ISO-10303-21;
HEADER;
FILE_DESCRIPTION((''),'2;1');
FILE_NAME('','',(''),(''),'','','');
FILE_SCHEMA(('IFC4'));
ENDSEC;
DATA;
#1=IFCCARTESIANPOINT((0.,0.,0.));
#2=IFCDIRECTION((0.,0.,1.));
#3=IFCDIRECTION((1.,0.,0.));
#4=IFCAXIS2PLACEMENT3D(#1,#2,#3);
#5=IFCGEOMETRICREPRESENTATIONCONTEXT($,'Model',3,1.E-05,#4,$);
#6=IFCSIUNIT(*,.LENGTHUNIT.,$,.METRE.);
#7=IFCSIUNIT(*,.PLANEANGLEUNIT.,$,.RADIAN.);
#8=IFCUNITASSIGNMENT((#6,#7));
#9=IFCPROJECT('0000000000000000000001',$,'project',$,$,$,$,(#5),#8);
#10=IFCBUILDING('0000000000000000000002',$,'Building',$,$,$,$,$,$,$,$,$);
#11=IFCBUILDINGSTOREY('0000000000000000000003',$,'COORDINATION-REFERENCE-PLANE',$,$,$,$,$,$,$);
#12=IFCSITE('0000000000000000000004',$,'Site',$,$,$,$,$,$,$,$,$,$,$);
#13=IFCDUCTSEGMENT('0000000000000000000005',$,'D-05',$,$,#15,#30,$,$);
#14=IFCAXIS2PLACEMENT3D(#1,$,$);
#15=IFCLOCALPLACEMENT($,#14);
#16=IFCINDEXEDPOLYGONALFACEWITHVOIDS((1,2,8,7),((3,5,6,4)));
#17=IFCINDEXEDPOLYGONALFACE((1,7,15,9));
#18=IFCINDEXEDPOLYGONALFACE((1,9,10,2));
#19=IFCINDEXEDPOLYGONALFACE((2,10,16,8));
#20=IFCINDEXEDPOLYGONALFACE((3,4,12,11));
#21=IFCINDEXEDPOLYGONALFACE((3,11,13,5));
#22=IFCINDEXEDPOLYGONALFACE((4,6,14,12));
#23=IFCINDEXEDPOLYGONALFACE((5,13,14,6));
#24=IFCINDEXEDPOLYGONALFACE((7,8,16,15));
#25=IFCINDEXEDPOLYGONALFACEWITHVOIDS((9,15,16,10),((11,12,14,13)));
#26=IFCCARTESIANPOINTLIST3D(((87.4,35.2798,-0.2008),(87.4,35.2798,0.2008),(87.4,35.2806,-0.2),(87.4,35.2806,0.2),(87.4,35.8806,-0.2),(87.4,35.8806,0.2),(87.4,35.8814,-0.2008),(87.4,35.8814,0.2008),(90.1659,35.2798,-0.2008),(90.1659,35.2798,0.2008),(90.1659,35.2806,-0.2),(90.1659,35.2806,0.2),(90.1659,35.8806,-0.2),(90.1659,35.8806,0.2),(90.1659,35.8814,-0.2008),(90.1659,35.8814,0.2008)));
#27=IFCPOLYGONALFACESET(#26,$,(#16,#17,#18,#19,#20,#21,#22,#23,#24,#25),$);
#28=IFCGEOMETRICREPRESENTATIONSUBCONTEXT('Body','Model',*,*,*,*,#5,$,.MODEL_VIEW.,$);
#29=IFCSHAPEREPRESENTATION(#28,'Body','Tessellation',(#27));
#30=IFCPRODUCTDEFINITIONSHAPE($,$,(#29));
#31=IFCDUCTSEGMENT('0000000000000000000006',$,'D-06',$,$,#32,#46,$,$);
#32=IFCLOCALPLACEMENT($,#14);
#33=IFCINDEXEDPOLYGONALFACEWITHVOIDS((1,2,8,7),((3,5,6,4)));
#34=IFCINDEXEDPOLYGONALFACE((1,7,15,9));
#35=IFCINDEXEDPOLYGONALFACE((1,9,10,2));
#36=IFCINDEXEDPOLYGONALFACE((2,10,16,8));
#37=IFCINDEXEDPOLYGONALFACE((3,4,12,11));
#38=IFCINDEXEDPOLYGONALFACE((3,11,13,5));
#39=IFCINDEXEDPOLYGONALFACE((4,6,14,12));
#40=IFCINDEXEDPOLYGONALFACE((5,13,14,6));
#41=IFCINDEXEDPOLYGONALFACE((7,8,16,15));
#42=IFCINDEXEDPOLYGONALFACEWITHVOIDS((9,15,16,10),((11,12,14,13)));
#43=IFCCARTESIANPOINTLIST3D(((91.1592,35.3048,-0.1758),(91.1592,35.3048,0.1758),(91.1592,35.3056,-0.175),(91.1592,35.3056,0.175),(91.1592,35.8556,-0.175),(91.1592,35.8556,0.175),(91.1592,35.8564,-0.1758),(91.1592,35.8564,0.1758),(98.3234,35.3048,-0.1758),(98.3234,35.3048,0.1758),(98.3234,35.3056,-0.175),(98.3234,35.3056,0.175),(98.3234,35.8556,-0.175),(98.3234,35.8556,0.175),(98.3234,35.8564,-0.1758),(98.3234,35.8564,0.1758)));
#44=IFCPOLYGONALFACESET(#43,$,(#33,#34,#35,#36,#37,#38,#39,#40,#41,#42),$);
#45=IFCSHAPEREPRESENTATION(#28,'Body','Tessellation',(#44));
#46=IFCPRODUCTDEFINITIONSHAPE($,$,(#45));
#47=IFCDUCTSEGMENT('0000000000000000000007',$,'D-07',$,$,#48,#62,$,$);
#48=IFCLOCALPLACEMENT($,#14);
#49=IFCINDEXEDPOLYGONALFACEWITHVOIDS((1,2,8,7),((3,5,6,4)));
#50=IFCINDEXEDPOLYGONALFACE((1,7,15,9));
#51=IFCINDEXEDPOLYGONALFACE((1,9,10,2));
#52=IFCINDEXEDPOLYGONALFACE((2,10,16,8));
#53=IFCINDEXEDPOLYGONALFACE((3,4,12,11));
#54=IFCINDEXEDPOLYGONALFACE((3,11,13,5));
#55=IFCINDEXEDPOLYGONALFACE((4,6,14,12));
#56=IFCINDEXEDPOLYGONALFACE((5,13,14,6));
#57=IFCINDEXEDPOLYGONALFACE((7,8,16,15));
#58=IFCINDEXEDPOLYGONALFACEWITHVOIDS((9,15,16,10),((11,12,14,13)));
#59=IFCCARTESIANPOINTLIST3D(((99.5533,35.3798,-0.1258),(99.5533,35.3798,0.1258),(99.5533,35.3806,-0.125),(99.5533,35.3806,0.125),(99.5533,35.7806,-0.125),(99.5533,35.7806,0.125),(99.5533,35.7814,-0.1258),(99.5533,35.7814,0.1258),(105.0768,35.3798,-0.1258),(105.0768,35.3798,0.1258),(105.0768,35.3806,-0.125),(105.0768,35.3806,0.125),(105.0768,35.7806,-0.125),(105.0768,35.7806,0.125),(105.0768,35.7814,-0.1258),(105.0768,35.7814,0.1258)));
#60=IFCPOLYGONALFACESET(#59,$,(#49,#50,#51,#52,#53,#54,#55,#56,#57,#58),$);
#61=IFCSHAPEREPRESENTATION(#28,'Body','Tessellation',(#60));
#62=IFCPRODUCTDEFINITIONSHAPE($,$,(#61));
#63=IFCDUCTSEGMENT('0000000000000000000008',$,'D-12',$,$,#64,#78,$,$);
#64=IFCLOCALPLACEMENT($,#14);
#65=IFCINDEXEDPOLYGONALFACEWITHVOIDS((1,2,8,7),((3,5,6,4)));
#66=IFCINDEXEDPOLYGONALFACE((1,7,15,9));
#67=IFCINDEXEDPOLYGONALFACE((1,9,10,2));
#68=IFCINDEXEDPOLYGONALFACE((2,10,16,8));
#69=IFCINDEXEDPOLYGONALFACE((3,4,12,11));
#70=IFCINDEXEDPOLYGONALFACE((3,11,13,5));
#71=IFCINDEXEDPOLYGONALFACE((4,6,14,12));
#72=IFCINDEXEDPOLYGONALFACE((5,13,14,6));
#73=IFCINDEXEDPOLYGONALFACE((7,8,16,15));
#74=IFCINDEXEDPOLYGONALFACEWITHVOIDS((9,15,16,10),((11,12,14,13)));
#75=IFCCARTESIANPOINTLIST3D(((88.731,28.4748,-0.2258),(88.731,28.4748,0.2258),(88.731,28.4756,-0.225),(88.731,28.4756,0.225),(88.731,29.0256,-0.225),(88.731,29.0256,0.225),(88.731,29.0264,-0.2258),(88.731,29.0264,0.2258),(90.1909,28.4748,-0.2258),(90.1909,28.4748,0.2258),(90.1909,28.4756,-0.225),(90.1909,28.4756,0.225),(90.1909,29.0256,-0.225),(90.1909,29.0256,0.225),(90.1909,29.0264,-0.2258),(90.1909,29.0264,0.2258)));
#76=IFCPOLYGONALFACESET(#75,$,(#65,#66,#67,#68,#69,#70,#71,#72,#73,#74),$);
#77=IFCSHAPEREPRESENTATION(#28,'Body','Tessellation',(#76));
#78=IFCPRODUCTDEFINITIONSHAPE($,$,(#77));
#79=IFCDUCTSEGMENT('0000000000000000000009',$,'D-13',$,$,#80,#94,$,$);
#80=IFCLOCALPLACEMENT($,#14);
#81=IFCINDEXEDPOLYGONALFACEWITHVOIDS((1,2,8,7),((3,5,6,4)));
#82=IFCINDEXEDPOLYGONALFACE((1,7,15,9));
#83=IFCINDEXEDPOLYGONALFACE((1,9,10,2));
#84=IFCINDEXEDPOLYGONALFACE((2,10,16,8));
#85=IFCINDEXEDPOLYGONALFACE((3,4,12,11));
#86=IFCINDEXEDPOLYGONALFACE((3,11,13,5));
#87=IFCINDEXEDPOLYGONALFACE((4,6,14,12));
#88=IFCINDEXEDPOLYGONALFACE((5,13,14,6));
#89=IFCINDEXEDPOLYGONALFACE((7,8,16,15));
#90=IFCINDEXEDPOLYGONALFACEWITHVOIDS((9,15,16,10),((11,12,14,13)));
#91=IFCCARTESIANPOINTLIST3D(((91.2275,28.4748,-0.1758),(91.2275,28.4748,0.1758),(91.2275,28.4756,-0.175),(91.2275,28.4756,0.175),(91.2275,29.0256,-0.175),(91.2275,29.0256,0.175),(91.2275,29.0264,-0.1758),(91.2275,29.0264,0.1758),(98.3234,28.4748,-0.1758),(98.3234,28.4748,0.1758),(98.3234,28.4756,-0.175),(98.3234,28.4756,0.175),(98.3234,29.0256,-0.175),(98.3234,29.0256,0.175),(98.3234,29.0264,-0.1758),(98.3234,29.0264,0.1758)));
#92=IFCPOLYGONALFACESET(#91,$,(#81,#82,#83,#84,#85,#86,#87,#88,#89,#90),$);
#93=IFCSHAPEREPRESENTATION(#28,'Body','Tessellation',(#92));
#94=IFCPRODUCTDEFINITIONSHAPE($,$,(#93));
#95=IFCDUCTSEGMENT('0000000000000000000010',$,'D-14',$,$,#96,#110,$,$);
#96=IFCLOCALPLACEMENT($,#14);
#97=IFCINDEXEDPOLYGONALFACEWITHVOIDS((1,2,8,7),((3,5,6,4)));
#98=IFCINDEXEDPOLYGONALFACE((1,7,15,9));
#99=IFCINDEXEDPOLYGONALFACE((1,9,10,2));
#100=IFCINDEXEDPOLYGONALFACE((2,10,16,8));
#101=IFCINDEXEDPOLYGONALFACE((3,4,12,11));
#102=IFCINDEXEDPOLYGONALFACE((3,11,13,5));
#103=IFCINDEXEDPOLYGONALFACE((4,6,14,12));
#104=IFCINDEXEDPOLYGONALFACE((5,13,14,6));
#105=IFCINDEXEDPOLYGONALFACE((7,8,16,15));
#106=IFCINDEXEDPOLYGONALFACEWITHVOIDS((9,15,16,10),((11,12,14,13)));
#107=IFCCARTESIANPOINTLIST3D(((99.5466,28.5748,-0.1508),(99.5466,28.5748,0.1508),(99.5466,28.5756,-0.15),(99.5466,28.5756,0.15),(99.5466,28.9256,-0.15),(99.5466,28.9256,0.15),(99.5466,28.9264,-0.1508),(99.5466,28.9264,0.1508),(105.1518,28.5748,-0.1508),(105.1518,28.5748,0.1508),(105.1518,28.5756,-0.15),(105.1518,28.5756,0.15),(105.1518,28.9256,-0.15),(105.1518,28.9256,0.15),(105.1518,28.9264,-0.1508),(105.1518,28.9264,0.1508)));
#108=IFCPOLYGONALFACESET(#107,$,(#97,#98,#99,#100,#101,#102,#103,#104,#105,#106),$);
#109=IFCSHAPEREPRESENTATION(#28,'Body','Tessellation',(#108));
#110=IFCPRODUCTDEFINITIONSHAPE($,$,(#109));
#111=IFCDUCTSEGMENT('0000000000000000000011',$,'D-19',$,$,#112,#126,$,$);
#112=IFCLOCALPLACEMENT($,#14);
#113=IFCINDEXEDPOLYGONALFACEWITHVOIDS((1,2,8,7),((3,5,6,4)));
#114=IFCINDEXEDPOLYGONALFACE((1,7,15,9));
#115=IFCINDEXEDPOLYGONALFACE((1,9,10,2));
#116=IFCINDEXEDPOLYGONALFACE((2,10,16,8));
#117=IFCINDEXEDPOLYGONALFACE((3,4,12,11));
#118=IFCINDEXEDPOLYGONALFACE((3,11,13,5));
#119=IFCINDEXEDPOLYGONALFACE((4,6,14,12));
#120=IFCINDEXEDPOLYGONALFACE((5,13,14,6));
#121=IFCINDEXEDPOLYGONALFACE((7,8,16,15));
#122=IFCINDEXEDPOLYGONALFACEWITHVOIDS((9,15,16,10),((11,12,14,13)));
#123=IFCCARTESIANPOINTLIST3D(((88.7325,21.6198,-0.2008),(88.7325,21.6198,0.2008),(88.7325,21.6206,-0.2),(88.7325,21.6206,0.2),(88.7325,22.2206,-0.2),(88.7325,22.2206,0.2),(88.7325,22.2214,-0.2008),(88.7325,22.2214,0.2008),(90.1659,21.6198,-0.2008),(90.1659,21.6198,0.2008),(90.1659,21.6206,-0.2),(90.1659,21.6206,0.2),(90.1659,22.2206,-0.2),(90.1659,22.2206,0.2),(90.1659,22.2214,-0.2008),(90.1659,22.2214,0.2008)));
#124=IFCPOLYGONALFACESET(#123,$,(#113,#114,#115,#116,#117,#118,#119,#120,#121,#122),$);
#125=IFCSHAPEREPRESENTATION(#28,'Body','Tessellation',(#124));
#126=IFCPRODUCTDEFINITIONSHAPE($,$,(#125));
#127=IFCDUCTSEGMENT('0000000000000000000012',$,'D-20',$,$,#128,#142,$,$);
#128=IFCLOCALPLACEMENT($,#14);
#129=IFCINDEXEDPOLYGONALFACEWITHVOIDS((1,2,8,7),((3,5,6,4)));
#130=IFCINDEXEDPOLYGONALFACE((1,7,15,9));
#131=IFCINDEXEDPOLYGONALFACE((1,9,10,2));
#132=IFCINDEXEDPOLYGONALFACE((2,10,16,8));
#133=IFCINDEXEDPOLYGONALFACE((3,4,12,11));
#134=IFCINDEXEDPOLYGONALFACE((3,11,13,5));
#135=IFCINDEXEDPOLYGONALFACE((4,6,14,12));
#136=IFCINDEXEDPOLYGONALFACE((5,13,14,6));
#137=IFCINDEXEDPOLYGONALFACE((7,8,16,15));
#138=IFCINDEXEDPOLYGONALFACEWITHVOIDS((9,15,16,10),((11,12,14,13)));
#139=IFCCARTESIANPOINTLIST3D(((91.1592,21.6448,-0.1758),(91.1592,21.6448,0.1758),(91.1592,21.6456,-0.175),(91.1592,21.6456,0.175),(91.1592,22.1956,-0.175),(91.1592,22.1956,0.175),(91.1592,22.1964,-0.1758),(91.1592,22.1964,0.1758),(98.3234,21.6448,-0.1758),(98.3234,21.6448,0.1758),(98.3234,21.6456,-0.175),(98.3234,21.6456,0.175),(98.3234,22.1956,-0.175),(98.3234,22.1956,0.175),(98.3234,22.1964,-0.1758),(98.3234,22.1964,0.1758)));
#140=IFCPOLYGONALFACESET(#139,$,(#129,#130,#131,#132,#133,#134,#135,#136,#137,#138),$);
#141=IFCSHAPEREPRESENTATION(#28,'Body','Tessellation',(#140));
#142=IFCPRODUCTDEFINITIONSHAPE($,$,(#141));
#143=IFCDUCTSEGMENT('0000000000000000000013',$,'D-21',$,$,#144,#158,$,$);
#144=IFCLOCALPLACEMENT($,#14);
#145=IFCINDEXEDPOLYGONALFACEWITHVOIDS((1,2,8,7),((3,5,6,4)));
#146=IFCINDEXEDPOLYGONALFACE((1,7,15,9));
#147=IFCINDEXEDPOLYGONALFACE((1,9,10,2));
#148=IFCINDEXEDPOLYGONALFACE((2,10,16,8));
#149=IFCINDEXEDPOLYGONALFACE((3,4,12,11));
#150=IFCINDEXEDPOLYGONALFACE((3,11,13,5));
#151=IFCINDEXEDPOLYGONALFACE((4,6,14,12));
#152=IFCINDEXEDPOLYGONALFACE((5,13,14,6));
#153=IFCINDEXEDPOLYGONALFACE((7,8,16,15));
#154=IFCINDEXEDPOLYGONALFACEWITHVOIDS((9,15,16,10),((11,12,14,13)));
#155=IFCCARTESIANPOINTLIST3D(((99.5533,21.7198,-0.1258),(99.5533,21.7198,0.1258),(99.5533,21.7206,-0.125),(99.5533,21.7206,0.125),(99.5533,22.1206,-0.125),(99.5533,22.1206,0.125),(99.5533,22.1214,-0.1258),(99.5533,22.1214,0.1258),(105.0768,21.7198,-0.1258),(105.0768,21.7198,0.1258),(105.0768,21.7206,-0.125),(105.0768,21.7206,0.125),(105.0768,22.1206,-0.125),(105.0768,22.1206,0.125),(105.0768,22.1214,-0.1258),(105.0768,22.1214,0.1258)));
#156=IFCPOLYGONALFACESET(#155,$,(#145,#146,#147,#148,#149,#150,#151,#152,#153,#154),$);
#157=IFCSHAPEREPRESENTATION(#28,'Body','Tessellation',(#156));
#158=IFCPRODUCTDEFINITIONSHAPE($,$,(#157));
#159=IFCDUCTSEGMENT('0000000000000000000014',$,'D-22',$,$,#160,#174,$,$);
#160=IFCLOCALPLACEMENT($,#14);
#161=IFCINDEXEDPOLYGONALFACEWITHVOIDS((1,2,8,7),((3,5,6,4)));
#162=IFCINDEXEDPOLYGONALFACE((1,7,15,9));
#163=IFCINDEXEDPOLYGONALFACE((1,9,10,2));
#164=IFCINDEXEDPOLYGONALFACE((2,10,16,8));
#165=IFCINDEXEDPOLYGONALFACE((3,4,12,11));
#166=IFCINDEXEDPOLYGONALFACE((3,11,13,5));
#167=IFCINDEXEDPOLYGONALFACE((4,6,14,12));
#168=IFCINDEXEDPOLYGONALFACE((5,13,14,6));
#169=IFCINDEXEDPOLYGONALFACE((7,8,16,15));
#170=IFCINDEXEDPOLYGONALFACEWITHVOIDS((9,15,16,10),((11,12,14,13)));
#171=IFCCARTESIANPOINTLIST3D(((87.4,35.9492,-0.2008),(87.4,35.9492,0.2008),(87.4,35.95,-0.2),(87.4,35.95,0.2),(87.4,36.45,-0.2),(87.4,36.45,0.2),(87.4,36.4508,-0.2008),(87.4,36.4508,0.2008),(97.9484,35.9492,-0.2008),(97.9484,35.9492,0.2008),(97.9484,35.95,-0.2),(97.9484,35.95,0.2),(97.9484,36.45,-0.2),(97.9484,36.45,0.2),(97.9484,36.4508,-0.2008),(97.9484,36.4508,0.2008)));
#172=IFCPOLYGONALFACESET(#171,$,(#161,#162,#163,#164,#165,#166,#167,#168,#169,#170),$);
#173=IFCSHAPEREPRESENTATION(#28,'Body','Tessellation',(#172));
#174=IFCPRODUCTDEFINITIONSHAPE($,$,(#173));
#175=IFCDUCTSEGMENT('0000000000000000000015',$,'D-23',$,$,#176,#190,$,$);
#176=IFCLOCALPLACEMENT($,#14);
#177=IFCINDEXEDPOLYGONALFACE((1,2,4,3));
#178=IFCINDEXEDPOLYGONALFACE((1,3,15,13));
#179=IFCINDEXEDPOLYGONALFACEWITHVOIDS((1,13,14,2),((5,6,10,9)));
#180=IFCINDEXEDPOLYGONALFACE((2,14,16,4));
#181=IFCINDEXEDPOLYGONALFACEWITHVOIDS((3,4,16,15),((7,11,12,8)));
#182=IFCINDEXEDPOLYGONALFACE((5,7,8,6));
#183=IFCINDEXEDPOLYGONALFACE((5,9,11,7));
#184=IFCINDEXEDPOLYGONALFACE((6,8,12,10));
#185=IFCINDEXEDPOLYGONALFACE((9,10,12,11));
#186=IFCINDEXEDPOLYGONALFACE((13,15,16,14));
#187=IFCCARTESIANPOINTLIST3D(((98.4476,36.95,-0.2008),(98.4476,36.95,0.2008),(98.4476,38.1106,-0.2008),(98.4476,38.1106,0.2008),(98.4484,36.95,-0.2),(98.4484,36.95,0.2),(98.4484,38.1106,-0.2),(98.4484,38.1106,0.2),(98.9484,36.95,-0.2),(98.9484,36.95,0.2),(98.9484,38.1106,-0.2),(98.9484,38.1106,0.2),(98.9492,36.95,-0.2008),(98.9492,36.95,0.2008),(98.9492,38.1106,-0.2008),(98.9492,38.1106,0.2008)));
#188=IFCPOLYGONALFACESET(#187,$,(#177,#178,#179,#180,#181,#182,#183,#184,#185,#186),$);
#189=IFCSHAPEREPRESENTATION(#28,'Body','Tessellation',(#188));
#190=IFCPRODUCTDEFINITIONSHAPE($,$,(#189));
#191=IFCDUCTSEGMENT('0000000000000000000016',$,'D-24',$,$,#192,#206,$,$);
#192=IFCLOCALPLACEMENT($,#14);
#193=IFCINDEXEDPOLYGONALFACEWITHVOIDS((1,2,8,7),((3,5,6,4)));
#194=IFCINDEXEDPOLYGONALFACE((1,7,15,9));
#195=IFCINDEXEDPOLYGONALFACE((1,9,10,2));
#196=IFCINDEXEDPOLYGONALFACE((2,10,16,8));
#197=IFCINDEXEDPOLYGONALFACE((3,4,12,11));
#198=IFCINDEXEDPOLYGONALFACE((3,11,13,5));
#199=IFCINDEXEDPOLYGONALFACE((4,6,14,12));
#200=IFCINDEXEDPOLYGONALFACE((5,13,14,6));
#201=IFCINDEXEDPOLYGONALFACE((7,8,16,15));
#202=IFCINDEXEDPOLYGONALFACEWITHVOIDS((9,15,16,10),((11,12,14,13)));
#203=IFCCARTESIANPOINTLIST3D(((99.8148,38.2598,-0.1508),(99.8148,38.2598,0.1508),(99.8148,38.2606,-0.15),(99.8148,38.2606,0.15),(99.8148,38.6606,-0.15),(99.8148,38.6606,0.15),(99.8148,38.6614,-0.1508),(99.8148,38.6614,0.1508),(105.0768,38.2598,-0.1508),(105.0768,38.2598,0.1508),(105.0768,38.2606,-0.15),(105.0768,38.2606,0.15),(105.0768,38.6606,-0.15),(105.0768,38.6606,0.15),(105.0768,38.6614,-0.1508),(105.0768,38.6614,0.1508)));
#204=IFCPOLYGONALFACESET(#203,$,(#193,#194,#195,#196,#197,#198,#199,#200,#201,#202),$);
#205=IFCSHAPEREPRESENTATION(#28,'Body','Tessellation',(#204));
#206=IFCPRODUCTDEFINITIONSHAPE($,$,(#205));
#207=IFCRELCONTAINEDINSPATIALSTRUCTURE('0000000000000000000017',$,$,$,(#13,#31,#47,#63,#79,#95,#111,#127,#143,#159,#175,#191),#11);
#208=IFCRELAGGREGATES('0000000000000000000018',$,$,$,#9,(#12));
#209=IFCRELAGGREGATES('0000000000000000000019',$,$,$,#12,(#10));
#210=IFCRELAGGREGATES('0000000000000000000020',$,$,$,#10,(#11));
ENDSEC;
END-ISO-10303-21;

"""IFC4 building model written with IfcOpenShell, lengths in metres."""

from ifc_helpers import new_model, si_unit, frame, origin, origin_with_axes, place, context, subcontext, project, spatial, hollow_rectangle, extrude, element, save


model = new_model("IFC4")

# Units and contexts
model_context = context("Model", 3, precision=1e-05, world=origin_with_axes())
body_context = subcontext(model_context, "Body", "Model", "MODEL_VIEW")
ifc_project = project(units=[si_unit("LENGTHUNIT", "METRE"), si_unit("PLANEANGLEUNIT", "RADIAN")], contexts=[model_context])

# Site, building, storey
site = spatial("IfcSite", under=ifc_project, Name="Site")
building = spatial("IfcBuilding", under=site, Name="Building")
storey = spatial("IfcBuildingStorey", under=building, Name="COORDINATION-REFERENCE-PLANE")

# Duct segments
duct_segment_1_placement = place(None, frame((87.4, 35.5806, 0.0), z_axis=(1.0, 0.0, 0.0), x_axis=(0.0, 1.0, 0.0)))
element("IfcDuctSegment", 1, at=duct_segment_1_placement, inside=storey, Name="D-05", context=body_context, shape_type="SweptSolid", body=[
    extrude(hollow_rectangle(XDim=0.6016, YDim=0.4016, WallThickness=0.0008), origin(), (0.0, 0.0, 1.0), 2.7659),
])
duct_segment_2_placement = place(None, frame((91.1592, 35.5806, 0.0), z_axis=(1.0, 0.0, 0.0), x_axis=(0.0, 1.0, 0.0)))
element("IfcDuctSegment", 2, at=duct_segment_2_placement, inside=storey, Name="D-06", context=body_context, shape_type="SweptSolid", body=[
    extrude(hollow_rectangle(XDim=0.5516, YDim=0.3516, WallThickness=0.0008), origin(), (0.0, 0.0, 1.0), 7.1642),
])
duct_segment_3_placement = place(None, frame((99.5533, 35.5806, 0.0), z_axis=(1.0, 0.0, 0.0), x_axis=(0.0, 1.0, 0.0)))
element("IfcDuctSegment", 3, at=duct_segment_3_placement, inside=storey, Name="D-07", context=body_context, shape_type="SweptSolid", body=[
    extrude(hollow_rectangle(XDim=0.4016, YDim=0.2516, WallThickness=0.0008), origin(), (0.0, 0.0, 1.0), 5.5234),
])
duct_segment_4_placement = place(None, frame((88.731, 28.7506, 0.0), z_axis=(1.0, 0.0, 0.0), x_axis=(0.0, 1.0, 0.0)))
element("IfcDuctSegment", 4, at=duct_segment_4_placement, inside=storey, Name="D-12", context=body_context, shape_type="SweptSolid", body=[
    extrude(hollow_rectangle(XDim=0.5516, YDim=0.4516, WallThickness=0.0008), origin(), (0.0, 0.0, 1.0), 1.4599),
])
duct_segment_5_placement = place(None, frame((91.2275, 28.7506, 0.0), z_axis=(1.0, 0.0, 0.0), x_axis=(0.0, 1.0, 0.0)))
element("IfcDuctSegment", 5, at=duct_segment_5_placement, inside=storey, Name="D-13", context=body_context, shape_type="SweptSolid", body=[
    extrude(hollow_rectangle(XDim=0.5516, YDim=0.3516, WallThickness=0.0008), origin(), (0.0, 0.0, 1.0), 7.0959),
])
duct_segment_6_placement = place(None, frame((99.5466, 28.7506, 0.0), z_axis=(1.0, 0.0, 0.0), x_axis=(0.0, 1.0, 0.0)))
element("IfcDuctSegment", 6, at=duct_segment_6_placement, inside=storey, Name="D-14", context=body_context, shape_type="SweptSolid", body=[
    extrude(hollow_rectangle(XDim=0.3516, YDim=0.3016, WallThickness=0.0008), origin(), (0.0, 0.0, 1.0), 5.6051),
])
duct_segment_7_placement = place(None, frame((88.7325, 21.9206, 0.0), z_axis=(1.0, 0.0, 0.0), x_axis=(0.0, 1.0, 0.0)))
element("IfcDuctSegment", 7, at=duct_segment_7_placement, inside=storey, Name="D-19", context=body_context, shape_type="SweptSolid", body=[
    extrude(hollow_rectangle(XDim=0.6016, YDim=0.4016, WallThickness=0.0008), origin(), (0.0, 0.0, 1.0), 1.4334),
])
duct_segment_8_placement = place(None, frame((91.1592, 21.9206, 0.0), z_axis=(1.0, 0.0, 0.0), x_axis=(0.0, 1.0, 0.0)))
element("IfcDuctSegment", 8, at=duct_segment_8_placement, inside=storey, Name="D-20", context=body_context, shape_type="SweptSolid", body=[
    extrude(hollow_rectangle(XDim=0.5516, YDim=0.3516, WallThickness=0.0008), origin(), (0.0, 0.0, 1.0), 7.1642),
])
duct_segment_9_placement = place(None, frame((99.5533, 21.9206, 0.0), z_axis=(1.0, 0.0, 0.0), x_axis=(0.0, 1.0, 0.0)))
element("IfcDuctSegment", 9, at=duct_segment_9_placement, inside=storey, Name="D-21", context=body_context, shape_type="SweptSolid", body=[
    extrude(hollow_rectangle(XDim=0.4016, YDim=0.2516, WallThickness=0.0008), origin(), (0.0, 0.0, 1.0), 5.5234),
])
duct_segment_10_placement = place(None, frame((87.4, 36.2, 0.0), z_axis=(1.0, 0.0, 0.0), x_axis=(0.0, 1.0, 0.0)))
element("IfcDuctSegment", 10, at=duct_segment_10_placement, inside=storey, Name="D-22", context=body_context, shape_type="SweptSolid", body=[
    extrude(hollow_rectangle(XDim=0.5016, YDim=0.4016, WallThickness=0.0008), origin(), (0.0, 0.0, 1.0), 10.5484),
])
duct_segment_11_placement = place(None, frame((98.6984, 36.95, 0.0), z_axis=(0.0, 1.0, 0.0), x_axis=(1.0, 0.0, 0.0)))
element("IfcDuctSegment", 11, at=duct_segment_11_placement, inside=storey, Name="D-23", context=body_context, shape_type="SweptSolid", body=[
    extrude(hollow_rectangle(XDim=0.5016, YDim=0.4016, WallThickness=0.0008), origin(), (0.0, 0.0, 1.0), 1.1606),
])
duct_segment_12_placement = place(None, frame((99.8148, 38.4606, 0.0), z_axis=(1.0, 0.0, 0.0), x_axis=(0.0, 1.0, 0.0)))
element("IfcDuctSegment", 12, at=duct_segment_12_placement, inside=storey, Name="D-24", context=body_context, shape_type="SweptSolid", body=[
    extrude(hollow_rectangle(XDim=0.4016, YDim=0.3016, WallThickness=0.0008), origin(), (0.0, 0.0, 1.0), 5.2619),
])

save(model, "model.ifc")
